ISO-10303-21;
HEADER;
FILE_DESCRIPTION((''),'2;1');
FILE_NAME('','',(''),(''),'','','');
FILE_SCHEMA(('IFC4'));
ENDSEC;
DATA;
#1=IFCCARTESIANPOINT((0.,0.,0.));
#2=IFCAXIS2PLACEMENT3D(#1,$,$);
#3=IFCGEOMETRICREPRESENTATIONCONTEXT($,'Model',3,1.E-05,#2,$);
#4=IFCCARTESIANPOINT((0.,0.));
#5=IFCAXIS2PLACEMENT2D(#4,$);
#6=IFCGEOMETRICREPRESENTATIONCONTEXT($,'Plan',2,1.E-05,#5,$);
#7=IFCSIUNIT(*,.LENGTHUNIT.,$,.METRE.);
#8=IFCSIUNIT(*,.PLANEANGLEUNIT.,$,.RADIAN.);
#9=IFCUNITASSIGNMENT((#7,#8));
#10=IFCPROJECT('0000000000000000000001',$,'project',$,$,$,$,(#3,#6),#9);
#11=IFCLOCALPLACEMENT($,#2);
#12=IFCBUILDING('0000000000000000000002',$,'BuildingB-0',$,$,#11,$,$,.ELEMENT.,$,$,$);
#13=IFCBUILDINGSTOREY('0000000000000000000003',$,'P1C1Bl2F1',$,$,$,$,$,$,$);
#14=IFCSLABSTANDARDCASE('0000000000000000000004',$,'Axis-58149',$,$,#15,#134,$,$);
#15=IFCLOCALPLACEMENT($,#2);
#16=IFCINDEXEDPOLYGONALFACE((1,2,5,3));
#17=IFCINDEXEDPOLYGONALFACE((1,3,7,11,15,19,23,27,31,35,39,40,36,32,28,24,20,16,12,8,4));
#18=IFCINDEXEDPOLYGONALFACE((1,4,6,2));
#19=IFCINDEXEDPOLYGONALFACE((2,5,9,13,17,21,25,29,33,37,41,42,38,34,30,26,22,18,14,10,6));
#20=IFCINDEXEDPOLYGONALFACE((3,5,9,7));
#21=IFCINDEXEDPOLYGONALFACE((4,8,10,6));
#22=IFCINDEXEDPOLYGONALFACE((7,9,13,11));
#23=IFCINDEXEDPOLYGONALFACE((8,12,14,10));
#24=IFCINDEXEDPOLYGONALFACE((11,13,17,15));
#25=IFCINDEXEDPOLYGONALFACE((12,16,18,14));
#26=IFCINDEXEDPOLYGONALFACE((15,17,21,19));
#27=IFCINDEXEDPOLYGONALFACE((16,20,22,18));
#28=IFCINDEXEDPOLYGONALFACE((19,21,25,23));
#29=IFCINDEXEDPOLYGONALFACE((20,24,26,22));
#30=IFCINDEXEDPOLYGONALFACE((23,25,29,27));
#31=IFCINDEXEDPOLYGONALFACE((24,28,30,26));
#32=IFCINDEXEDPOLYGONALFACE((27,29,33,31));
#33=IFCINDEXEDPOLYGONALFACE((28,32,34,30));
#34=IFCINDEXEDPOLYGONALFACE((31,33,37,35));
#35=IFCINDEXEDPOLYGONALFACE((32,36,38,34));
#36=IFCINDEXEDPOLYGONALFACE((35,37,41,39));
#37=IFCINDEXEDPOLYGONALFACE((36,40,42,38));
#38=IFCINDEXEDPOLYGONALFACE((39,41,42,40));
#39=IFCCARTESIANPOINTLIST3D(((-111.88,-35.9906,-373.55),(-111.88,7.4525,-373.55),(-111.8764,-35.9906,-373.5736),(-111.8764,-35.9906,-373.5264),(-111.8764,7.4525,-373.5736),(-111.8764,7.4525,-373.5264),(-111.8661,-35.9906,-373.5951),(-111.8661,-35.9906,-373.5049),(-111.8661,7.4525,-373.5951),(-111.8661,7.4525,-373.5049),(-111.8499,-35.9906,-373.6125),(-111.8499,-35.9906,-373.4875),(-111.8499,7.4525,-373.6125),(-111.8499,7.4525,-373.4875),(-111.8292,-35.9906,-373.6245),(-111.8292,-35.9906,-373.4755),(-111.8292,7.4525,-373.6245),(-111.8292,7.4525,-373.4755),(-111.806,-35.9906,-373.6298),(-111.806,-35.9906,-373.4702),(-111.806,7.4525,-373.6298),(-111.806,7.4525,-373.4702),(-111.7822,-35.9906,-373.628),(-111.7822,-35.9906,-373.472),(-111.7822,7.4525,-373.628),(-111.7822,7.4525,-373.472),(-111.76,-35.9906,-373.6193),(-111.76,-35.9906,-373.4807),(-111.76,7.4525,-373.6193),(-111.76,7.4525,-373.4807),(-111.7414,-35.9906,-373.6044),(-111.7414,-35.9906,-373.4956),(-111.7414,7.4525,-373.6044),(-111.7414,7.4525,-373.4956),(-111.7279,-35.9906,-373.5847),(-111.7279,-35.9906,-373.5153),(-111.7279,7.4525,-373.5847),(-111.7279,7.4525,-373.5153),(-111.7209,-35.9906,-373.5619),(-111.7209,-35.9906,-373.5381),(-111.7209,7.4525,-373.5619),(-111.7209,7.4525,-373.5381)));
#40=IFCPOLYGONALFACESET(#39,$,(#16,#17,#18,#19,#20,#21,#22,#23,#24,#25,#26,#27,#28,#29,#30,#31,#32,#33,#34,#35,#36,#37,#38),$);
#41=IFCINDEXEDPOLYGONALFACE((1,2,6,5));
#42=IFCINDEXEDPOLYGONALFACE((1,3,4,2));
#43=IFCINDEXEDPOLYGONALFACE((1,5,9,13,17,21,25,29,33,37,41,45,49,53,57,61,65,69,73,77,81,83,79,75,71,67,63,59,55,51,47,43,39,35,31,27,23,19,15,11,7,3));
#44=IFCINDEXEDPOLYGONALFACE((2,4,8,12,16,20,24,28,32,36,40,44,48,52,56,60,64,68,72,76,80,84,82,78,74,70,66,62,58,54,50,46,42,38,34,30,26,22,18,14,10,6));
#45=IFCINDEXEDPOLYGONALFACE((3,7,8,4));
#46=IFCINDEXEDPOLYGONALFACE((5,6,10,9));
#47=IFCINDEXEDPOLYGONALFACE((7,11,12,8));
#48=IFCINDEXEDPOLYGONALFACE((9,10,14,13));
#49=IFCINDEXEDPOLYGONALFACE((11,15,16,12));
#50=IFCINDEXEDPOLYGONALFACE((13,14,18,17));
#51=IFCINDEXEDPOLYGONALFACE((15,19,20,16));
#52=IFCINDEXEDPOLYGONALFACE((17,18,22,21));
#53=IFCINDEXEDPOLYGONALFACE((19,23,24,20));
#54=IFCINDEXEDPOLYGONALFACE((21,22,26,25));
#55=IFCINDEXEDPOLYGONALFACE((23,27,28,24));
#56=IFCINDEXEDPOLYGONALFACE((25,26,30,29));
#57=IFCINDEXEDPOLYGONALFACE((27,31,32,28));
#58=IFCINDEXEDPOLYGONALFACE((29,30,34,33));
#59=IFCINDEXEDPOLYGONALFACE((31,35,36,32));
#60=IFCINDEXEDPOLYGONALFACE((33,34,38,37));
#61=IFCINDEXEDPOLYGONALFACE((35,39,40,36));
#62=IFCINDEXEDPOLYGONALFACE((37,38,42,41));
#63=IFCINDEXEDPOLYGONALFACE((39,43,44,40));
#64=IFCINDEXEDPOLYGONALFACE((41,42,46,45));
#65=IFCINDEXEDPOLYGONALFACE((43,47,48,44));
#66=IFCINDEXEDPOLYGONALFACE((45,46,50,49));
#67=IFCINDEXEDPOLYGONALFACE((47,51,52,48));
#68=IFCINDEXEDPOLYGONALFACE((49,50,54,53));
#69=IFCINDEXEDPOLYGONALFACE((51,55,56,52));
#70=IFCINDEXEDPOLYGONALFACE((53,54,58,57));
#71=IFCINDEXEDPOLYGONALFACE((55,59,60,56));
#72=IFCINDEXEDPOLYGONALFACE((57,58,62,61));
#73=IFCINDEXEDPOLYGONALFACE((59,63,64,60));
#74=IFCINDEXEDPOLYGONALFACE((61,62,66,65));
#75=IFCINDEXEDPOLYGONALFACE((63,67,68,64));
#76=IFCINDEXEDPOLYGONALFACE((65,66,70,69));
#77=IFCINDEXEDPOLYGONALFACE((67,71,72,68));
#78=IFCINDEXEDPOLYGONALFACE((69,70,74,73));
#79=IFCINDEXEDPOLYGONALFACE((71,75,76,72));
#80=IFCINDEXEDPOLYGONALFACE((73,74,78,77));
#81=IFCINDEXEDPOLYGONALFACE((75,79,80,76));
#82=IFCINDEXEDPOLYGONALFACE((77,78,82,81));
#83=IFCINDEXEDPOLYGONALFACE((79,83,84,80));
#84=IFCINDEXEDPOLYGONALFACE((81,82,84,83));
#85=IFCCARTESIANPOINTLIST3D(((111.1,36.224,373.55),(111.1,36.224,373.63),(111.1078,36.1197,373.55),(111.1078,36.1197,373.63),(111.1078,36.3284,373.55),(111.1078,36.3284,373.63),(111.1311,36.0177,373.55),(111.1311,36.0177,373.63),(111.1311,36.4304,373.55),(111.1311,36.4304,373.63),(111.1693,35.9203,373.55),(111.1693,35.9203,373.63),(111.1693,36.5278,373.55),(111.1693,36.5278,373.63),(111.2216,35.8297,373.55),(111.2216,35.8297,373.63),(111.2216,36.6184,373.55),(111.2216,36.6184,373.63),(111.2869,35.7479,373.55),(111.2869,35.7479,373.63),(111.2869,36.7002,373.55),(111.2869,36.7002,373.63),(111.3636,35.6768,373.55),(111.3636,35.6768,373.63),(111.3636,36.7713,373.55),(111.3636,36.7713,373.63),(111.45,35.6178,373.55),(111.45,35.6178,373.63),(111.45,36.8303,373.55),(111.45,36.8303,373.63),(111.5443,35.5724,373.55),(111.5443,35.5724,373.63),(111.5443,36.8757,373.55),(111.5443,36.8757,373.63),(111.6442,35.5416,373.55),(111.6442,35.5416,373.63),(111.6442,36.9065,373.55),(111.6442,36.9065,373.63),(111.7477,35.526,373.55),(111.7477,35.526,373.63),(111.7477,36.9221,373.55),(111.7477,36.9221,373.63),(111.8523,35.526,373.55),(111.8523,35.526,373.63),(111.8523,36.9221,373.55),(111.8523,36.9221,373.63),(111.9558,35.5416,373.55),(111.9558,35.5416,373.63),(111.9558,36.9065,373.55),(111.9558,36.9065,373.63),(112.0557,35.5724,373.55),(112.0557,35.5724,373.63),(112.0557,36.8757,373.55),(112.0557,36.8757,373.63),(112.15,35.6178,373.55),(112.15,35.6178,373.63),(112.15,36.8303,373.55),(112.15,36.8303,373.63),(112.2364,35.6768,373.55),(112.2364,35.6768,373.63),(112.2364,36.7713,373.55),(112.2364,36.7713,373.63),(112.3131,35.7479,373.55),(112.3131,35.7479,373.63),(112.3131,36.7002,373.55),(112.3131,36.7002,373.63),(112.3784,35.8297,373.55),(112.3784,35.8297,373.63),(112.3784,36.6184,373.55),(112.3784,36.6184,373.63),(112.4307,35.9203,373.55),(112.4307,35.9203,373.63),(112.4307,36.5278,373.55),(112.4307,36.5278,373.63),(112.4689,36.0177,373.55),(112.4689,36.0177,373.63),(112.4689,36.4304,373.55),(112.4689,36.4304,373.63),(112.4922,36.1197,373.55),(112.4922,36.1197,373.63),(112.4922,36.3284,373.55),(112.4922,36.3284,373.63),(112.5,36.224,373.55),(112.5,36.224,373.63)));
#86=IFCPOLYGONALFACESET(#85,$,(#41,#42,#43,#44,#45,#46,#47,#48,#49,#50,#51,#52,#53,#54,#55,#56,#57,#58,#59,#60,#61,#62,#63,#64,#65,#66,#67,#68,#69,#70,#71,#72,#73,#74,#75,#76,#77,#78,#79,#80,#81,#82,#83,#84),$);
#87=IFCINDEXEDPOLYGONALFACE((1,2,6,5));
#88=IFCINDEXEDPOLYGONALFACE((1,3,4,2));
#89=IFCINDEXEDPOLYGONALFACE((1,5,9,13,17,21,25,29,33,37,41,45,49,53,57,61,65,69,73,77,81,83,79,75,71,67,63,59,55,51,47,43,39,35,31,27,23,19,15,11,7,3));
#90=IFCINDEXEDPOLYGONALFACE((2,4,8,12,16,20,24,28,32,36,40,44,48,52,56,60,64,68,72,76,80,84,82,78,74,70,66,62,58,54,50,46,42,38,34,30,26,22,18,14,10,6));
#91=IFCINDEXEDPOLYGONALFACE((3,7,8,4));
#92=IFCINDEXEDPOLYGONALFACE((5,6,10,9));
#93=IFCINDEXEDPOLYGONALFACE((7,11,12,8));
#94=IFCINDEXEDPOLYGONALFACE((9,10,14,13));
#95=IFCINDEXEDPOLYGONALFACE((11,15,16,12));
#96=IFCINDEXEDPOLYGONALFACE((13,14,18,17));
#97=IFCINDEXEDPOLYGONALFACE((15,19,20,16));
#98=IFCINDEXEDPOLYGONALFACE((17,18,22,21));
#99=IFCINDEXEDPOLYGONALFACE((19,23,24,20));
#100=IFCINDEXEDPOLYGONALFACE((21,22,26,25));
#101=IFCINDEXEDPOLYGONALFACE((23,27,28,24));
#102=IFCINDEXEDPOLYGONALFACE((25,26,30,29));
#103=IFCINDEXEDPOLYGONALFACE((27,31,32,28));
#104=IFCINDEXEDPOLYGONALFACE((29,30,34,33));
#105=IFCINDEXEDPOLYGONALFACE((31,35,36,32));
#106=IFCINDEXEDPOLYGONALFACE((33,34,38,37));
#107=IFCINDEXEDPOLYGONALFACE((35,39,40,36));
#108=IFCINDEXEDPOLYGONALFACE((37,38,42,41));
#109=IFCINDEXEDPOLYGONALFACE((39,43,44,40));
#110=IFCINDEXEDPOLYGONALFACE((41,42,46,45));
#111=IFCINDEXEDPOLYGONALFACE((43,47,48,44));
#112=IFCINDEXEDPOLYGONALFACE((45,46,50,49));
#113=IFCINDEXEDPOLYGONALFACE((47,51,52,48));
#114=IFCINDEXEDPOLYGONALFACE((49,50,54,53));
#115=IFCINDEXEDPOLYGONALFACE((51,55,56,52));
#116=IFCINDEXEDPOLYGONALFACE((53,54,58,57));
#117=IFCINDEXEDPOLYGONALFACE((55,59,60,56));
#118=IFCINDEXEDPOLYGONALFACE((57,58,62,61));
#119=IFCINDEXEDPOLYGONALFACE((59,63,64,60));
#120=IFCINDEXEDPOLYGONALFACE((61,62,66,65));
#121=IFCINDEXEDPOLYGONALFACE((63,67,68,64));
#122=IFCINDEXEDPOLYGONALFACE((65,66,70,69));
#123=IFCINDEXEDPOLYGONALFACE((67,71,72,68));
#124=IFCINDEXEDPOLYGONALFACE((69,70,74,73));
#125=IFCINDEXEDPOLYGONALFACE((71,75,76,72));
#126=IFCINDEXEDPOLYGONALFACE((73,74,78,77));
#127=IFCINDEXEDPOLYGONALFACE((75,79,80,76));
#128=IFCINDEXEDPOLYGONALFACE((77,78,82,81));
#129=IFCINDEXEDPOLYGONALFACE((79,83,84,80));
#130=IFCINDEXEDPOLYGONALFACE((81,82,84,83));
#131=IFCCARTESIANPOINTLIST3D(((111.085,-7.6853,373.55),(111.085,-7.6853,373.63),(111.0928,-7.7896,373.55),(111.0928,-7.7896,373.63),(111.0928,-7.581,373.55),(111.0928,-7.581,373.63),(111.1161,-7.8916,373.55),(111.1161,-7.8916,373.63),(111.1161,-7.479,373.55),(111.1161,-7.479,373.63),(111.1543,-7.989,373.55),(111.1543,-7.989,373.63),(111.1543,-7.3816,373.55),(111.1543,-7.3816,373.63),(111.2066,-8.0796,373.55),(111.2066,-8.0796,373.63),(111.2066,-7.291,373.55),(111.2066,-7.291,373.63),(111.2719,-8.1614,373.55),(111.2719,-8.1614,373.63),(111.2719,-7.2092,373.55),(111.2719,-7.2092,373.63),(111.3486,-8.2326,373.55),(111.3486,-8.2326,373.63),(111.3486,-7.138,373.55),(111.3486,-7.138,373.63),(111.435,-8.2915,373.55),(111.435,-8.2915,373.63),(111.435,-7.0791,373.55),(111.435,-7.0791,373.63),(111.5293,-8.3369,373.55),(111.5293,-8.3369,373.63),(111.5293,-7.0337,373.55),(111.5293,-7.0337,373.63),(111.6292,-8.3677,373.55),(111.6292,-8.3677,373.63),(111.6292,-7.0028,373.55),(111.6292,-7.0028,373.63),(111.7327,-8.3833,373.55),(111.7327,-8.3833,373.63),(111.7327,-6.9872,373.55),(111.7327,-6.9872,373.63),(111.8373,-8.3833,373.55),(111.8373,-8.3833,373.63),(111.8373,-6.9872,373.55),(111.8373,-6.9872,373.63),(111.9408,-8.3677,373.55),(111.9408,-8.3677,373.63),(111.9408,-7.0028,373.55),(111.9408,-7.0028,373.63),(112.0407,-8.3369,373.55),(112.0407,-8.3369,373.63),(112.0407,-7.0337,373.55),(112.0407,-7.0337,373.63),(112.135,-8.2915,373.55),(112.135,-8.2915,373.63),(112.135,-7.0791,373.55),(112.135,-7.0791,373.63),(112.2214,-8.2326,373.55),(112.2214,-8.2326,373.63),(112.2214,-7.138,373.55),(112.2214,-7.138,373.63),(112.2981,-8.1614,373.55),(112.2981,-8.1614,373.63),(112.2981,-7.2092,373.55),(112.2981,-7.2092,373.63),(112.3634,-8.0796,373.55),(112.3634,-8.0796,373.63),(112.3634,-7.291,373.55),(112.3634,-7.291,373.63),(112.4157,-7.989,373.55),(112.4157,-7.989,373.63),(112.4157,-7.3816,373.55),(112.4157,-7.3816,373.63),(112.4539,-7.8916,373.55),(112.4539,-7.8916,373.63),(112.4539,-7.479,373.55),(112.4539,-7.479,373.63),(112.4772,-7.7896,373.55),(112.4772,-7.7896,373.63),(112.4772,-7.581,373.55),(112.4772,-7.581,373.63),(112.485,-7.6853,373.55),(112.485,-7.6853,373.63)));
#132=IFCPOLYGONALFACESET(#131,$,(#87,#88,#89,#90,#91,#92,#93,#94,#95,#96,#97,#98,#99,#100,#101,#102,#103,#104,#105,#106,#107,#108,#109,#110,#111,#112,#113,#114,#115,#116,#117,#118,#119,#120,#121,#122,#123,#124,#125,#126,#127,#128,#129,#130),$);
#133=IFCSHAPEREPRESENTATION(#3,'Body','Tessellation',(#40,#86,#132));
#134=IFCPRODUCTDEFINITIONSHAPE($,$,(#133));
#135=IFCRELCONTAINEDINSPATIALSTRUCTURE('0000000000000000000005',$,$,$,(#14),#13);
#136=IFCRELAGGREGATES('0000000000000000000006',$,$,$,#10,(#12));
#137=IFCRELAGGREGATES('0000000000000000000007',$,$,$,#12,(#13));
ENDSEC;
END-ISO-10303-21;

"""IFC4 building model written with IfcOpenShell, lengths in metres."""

from ifc_helpers import new_model, entity, si_unit, frame, origin, origin_2d, place, context, project, spatial, circle, extrude, element, save


model = new_model("IFC4")

# Units and contexts
model_context = context("Model", 3, precision=1e-05, world=origin())
plan_context = context("Plan", 2, precision=1e-05, world=origin_2d())
ifc_project = project(units=[si_unit("LENGTHUNIT", "METRE"), si_unit("PLANEANGLEUNIT", "RADIAN")], contexts=[model_context, plan_context])

# Building, storey
building_placement = place(None, origin())
building = spatial("IfcBuilding", under=ifc_project, at=building_placement, Name="BuildingB-0", CompositionType="ELEMENT")
storey = spatial("IfcBuildingStorey", under=building, Name="P1C1Bl2F1")

# Slab
element("IfcSlabStandardCase", 1, inside=storey, Name="Axis-58149", context=model_context, shape_type="AdvancedSweptSolid", body=[
    entity("IfcSurfaceCurveSweptAreaSolid", entity("IfcCircleProfileDef", "AREA", None, None, 0.08), None, entity("IfcPolyline", [entity("IfcCartesianPoint", [111.8, 35.9906, 373.55]), entity("IfcCartesianPoint", [111.8, -7.4525, 373.55])]), None, None, entity("IfcPlane", entity("IfcAxis2Placement3D", entity("IfcCartesianPoint", [111.8, 35.9906, 373.55]), entity("IfcDirection", [0.0, 0.0, 1.0]), entity("IfcDirection", [1.0, 0.0, 0.0])))),
    extrude(circle(Radius=0.7), frame((111.8, 36.224, 373.55)), (0.0, 0.0, 1.0), 0.08),
    extrude(circle(Radius=0.7), frame((111.785, -7.6853, 373.55)), (0.0, 0.0, 1.0), 0.08),
])

save(model, "model.ifc")
